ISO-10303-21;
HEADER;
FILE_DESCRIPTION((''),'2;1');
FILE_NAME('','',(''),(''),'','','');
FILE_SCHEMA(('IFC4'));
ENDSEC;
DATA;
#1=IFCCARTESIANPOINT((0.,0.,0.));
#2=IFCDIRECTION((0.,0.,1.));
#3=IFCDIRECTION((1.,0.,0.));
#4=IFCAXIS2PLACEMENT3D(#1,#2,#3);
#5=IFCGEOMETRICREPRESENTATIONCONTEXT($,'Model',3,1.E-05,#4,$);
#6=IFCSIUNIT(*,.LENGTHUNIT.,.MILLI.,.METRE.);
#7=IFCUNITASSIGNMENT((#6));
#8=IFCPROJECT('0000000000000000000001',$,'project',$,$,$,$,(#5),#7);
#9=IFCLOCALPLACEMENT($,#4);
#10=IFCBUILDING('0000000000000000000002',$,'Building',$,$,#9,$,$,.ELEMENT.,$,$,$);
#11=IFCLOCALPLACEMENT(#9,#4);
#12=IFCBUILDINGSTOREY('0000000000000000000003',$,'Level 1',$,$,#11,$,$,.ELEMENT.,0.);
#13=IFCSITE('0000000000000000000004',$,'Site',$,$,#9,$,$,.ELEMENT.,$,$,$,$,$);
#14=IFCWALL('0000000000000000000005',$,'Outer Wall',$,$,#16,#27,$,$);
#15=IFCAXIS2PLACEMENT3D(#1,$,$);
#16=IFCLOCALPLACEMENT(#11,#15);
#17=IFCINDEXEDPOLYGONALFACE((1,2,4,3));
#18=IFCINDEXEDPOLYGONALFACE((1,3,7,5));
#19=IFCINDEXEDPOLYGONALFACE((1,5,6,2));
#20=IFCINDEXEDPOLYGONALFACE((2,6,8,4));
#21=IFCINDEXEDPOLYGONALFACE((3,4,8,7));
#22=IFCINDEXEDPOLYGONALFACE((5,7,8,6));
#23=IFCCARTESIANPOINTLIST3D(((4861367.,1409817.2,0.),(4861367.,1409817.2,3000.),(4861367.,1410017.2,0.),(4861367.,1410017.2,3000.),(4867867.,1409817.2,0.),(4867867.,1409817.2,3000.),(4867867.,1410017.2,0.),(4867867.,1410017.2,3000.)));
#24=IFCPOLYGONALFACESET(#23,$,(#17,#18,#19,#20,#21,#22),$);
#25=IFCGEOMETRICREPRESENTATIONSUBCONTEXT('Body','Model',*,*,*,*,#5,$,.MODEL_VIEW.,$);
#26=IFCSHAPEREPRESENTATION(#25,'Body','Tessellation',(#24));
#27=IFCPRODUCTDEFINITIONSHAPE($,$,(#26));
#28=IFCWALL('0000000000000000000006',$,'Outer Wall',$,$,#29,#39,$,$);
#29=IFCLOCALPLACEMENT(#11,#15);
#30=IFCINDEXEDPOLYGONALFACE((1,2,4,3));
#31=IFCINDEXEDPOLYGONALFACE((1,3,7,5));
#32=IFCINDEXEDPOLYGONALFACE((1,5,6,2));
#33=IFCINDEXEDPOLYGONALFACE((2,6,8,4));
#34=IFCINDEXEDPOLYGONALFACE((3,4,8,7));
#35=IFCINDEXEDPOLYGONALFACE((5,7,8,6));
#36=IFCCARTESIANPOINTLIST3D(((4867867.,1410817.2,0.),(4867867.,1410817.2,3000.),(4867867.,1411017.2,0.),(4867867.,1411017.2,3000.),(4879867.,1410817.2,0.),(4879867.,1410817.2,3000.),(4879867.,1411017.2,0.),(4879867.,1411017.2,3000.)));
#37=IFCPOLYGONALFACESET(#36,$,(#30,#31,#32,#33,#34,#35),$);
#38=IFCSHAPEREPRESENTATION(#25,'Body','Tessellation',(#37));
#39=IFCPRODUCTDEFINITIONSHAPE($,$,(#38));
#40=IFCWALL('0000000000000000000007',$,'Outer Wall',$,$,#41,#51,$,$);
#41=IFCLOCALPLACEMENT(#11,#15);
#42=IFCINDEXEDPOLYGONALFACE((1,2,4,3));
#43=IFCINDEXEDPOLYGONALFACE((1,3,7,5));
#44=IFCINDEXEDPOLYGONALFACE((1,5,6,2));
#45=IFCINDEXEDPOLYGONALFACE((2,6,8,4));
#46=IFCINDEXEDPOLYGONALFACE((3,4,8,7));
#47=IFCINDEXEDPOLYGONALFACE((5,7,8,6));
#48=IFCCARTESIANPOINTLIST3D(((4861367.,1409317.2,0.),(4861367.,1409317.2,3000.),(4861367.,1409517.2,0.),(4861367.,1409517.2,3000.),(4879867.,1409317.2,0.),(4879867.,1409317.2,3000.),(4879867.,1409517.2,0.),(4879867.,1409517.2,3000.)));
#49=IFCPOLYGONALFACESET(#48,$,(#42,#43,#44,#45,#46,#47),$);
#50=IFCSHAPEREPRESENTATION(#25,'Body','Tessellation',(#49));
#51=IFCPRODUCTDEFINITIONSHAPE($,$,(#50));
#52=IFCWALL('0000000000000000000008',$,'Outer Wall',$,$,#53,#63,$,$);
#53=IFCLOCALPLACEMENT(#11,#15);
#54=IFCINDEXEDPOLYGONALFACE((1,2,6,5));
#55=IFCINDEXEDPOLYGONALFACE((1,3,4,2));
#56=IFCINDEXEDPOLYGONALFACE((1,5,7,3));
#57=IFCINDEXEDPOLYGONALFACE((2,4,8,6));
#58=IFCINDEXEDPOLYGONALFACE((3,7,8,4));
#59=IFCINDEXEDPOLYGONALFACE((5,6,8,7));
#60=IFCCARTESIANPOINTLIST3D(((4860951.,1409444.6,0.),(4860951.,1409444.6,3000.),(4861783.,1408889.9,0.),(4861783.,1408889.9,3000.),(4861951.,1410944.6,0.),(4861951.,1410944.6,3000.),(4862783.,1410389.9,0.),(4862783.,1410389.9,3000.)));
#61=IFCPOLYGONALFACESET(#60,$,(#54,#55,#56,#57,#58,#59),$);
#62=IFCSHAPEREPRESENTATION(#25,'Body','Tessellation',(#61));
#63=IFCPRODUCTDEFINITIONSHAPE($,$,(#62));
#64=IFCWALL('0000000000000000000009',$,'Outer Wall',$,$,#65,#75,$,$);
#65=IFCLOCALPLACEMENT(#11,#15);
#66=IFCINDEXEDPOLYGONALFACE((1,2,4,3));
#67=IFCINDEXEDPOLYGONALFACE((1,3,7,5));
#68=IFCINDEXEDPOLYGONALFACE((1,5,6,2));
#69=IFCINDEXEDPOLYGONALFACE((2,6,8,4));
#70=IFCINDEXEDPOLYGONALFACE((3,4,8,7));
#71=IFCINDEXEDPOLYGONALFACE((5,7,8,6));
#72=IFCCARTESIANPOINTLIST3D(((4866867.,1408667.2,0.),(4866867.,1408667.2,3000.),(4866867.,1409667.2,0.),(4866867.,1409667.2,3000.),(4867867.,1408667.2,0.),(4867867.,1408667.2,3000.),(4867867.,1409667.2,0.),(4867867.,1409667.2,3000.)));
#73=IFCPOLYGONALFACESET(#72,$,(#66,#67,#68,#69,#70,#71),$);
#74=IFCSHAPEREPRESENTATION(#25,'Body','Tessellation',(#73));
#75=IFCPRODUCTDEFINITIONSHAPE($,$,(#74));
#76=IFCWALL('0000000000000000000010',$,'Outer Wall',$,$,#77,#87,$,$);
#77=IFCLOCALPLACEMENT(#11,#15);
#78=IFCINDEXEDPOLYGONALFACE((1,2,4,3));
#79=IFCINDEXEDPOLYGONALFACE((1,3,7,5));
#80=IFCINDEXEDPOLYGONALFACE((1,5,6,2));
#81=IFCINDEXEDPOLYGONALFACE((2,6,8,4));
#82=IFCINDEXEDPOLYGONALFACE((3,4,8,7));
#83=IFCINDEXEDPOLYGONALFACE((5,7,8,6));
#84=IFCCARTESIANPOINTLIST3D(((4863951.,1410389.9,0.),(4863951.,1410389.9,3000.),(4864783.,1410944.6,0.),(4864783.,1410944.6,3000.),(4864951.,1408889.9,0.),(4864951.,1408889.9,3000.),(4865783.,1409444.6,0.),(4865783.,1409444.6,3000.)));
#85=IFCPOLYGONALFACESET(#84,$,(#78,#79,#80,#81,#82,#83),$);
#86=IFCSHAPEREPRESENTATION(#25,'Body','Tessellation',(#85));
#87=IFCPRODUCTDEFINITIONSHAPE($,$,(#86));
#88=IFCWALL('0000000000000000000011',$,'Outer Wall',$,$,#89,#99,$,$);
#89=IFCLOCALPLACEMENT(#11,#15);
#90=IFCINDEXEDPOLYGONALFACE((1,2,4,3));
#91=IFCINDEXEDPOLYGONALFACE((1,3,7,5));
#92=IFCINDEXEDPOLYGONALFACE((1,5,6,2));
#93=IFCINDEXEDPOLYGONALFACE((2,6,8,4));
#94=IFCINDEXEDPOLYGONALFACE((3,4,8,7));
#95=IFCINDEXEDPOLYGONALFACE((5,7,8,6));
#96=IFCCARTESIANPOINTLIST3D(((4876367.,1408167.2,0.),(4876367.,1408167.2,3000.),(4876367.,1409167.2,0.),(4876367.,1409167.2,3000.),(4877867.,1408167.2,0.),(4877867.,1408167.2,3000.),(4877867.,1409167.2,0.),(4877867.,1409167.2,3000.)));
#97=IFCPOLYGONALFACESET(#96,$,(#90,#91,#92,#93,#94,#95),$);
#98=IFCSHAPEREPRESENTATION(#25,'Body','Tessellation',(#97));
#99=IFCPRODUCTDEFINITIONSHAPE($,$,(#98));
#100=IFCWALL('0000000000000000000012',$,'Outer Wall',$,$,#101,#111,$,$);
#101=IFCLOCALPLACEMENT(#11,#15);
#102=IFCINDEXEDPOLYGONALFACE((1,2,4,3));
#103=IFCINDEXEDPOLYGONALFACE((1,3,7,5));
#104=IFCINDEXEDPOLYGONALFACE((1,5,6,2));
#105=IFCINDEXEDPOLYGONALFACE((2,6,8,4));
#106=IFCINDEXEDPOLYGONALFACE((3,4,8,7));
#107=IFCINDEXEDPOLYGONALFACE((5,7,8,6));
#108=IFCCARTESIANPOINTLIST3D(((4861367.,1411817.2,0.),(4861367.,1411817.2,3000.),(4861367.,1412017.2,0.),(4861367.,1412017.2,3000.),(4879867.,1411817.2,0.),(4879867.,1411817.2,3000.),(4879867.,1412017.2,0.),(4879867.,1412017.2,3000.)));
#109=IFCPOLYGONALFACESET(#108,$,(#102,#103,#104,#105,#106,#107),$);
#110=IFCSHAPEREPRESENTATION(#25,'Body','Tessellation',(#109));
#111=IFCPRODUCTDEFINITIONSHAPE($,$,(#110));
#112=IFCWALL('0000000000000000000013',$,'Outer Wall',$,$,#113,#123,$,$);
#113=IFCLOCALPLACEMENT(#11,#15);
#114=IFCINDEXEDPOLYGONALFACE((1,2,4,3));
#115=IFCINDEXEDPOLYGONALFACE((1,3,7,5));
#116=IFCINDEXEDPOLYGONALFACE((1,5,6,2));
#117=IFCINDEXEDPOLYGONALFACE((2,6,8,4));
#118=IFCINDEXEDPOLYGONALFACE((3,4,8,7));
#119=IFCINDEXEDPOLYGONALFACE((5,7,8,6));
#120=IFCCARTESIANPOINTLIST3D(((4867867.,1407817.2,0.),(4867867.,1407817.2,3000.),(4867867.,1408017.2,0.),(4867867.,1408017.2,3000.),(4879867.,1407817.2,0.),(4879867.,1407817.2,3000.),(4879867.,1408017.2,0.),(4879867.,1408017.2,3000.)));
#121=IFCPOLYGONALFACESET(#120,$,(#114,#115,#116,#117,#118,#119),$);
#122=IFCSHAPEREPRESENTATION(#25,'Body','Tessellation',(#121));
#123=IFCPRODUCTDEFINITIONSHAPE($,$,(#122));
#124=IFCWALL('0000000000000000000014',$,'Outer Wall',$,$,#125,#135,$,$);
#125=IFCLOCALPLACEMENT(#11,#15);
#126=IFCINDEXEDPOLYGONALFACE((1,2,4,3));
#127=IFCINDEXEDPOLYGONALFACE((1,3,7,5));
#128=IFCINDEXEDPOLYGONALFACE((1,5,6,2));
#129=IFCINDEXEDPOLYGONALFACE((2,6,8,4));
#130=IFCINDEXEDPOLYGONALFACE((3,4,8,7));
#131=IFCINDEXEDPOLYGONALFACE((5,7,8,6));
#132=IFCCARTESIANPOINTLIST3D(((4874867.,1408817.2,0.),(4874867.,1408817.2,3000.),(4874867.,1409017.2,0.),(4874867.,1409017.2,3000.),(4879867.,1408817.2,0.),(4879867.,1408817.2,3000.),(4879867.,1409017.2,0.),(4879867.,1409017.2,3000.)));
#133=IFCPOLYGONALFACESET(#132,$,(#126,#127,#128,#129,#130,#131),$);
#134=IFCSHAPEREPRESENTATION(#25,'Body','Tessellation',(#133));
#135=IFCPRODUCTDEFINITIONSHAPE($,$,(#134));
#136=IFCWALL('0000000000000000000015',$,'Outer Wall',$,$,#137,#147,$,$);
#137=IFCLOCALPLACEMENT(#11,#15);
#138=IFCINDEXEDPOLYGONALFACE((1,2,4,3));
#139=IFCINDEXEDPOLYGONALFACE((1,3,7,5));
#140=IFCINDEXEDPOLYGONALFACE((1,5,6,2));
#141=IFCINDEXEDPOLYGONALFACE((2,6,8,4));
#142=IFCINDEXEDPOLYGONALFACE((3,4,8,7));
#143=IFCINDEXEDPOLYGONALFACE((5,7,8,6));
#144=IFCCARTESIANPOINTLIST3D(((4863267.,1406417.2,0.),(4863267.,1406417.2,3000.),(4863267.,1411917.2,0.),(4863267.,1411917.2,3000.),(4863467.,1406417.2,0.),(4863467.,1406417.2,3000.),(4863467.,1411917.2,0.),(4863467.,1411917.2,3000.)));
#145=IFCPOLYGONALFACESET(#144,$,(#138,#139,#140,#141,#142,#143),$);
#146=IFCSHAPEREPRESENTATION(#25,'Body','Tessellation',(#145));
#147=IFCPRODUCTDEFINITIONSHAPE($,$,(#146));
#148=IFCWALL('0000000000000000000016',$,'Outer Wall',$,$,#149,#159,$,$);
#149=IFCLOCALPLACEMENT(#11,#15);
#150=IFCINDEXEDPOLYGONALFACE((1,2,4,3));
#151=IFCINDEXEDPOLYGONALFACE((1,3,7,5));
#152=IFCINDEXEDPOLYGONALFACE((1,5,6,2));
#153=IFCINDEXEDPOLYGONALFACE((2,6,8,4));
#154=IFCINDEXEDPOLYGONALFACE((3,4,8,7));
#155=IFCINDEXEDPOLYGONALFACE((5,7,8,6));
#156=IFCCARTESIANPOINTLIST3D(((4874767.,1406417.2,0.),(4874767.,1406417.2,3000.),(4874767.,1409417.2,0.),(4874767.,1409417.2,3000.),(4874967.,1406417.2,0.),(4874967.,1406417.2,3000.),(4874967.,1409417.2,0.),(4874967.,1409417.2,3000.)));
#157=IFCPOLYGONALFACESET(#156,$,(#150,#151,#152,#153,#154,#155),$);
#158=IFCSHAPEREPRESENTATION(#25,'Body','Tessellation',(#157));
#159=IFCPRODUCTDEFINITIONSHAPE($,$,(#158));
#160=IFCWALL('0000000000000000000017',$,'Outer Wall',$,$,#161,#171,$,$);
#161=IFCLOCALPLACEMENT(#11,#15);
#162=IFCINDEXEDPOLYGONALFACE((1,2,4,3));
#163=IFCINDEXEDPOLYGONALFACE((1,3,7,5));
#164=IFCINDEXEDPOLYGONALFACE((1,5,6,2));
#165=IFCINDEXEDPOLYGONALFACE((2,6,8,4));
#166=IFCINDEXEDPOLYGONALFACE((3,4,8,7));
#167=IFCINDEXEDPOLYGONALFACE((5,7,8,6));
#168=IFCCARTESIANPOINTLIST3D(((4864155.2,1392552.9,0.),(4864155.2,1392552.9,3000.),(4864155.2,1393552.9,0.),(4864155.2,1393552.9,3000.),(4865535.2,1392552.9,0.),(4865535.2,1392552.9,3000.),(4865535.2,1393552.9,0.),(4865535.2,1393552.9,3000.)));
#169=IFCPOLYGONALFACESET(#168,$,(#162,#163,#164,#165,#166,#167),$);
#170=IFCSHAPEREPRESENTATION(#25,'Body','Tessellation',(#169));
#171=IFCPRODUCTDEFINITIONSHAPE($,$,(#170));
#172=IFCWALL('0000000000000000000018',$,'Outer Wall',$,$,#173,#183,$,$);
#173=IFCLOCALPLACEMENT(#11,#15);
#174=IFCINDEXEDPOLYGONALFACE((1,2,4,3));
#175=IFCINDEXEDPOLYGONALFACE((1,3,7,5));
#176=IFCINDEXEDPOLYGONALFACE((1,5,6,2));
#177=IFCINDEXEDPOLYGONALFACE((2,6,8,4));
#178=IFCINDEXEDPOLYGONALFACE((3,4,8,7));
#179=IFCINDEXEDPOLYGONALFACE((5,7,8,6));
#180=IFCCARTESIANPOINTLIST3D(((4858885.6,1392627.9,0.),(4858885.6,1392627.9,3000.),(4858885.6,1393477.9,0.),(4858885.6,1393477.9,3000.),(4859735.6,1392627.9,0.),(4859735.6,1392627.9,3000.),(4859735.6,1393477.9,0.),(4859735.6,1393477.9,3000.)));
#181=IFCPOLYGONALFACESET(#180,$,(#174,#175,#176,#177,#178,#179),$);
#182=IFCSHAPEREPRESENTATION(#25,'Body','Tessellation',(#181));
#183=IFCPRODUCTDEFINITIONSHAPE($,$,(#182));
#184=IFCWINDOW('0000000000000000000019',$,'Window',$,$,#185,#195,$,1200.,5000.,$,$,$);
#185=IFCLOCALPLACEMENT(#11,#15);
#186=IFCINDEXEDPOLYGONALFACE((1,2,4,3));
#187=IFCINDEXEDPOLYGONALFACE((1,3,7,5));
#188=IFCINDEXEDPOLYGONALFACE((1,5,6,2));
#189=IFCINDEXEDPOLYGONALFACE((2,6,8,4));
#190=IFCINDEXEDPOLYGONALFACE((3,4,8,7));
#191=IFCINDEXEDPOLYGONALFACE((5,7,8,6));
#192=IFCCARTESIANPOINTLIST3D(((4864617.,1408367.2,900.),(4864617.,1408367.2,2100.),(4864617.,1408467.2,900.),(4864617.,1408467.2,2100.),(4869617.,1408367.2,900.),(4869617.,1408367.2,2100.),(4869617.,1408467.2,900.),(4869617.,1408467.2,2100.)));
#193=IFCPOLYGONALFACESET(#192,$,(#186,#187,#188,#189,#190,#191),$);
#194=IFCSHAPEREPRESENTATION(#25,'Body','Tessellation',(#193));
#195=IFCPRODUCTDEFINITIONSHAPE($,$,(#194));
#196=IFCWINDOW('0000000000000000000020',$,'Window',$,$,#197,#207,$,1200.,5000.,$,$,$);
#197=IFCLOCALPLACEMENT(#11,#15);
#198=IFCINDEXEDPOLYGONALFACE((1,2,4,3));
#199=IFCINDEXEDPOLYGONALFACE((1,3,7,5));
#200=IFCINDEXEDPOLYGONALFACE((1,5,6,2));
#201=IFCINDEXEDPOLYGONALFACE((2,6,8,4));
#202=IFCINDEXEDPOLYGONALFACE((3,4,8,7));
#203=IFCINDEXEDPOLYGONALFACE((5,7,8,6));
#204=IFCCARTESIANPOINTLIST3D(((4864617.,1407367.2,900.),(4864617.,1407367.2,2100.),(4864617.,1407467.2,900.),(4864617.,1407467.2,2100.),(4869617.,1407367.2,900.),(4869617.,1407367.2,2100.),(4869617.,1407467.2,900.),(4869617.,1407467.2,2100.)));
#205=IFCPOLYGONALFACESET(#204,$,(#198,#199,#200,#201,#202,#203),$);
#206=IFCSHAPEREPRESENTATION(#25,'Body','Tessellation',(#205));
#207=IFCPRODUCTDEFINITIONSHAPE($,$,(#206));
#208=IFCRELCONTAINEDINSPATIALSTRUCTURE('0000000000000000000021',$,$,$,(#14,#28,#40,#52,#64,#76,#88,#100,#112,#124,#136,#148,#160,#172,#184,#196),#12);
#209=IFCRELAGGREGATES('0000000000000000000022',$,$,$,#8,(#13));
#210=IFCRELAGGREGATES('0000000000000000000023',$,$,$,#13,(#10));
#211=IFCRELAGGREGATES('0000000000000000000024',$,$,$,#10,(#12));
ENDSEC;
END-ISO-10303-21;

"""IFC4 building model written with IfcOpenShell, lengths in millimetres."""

from ifc_helpers import new_model, si_unit, frame, frame_2d, origin_with_axes, place, context, subcontext, project, spatial, rectangle, extrude, element, save


model = new_model("IFC4")

# Units and contexts
model_context = context("Model", 3, precision=1e-05, world=origin_with_axes())
body_context = subcontext(model_context, "Body", "Model", "MODEL_VIEW")
ifc_project = project(units=[si_unit("LENGTHUNIT", "METRE", prefix="MILLI")], contexts=[model_context])

# Site, building, storey
placement = place(None, origin_with_axes())
site = spatial("IfcSite", under=ifc_project, at=placement, Name="Site", CompositionType="ELEMENT")
building = spatial("IfcBuilding", under=site, at=placement, Name="Building", CompositionType="ELEMENT")
storey_placement = place(placement, origin_with_axes())
storey = spatial("IfcBuildingStorey", under=building, at=storey_placement, Name="Level 1", CompositionType="ELEMENT", Elevation=0.0)

# Walls
wall_1_placement = place(placement, frame((4861367.0, 1409917.2, 0.0), z_axis=(0.0, 0.0, 1.0), x_axis=(1.0, 0.0, 0.0)))
element("IfcWall", 1, at=wall_1_placement, inside=storey, Name="Outer Wall", context=body_context, shape_type="SweptSolid", body=[
    extrude(rectangle(XDim=6500.0, YDim=200.0, at=frame_2d((3250.0, 0.0), x_axis=(1.0, 0.0))), origin_with_axes(), (0.0, 0.0, 1.0), 3000.0),
])
wall_2_placement = place(placement, frame((4867867.0, 1410917.2, 0.0), z_axis=(0.0, 0.0, 1.0), x_axis=(1.0, 0.0, 0.0)))
element("IfcWall", 2, at=wall_2_placement, inside=storey, Name="Outer Wall", context=body_context, shape_type="SweptSolid", body=[
    extrude(rectangle(XDim=12000.0, YDim=200.0, at=frame_2d((6000.0, 0.0), x_axis=(1.0, 0.0))), origin_with_axes(), (0.0, 0.0, 1.0), 3000.0),
])
wall_3_placement = place(placement, frame((4861367.0, 1409417.2, 0.0), z_axis=(0.0, 0.0, 1.0), x_axis=(1.0, 0.0, 0.0)))
element("IfcWall", 3, at=wall_3_placement, inside=storey, Name="Outer Wall", context=body_context, shape_type="SweptSolid", body=[
    extrude(rectangle(XDim=18500.0, YDim=200.0, at=frame_2d((9250.0, 0.0), x_axis=(1.0, 0.0))), origin_with_axes(), (0.0, 0.0, 1.0), 3000.0),
])
wall_4_placement = place(placement, frame((4862367.0, 1410667.2, 0.0), z_axis=(0.0, 0.0, 1.0), x_axis=(-0.5547, -0.83205, 0.0)))
element("IfcWall", 4, at=wall_4_placement, inside=storey, Name="Outer Wall", context=body_context, shape_type="SweptSolid", body=[
    extrude(rectangle(XDim=1802.8, YDim=1000.0, at=frame_2d((901.4, 0.0), x_axis=(1.0, 0.0))), origin_with_axes(), (0.0, 0.0, 1.0), 3000.0),
])
wall_5_placement = place(placement, frame((4866867.0, 1409167.2, 0.0), z_axis=(0.0, 0.0, 1.0), x_axis=(1.0, 0.0, 0.0)))
element("IfcWall", 5, at=wall_5_placement, inside=storey, Name="Outer Wall", context=body_context, shape_type="SweptSolid", body=[
    extrude(rectangle(XDim=1000.0, YDim=1000.0, at=frame_2d((500.0, 0.0), x_axis=(1.0, 0.0))), origin_with_axes(), (0.0, 0.0, 1.0), 3000.0),
])
wall_6_placement = place(placement, frame((4865367.0, 1409167.2, 0.0), z_axis=(0.0, 0.0, 1.0), x_axis=(-0.5547, 0.83205, 0.0)))
element("IfcWall", 6, at=wall_6_placement, inside=storey, Name="Outer Wall", context=body_context, shape_type="SweptSolid", body=[
    extrude(rectangle(XDim=1802.8, YDim=1000.0, at=frame_2d((901.4, 0.0), x_axis=(1.0, 0.0))), origin_with_axes(), (0.0, 0.0, 1.0), 3000.0),
])
wall_7_placement = place(placement, frame((4877867.0, 1408667.2, 0.0), z_axis=(0.0, 0.0, 1.0), x_axis=(-1.0, 0.0, 0.0)))
element("IfcWall", 7, at=wall_7_placement, inside=storey, Name="Outer Wall", context=body_context, shape_type="SweptSolid", body=[
    extrude(rectangle(XDim=1500.0, YDim=1000.0, at=frame_2d((750.0, 0.0), x_axis=(1.0, 0.0))), origin_with_axes(), (0.0, 0.0, 1.0), 3000.0),
])
wall_8_placement = place(placement, frame((4861367.0, 1411917.2, 0.0), z_axis=(0.0, 0.0, 1.0), x_axis=(1.0, 0.0, 0.0)))
element("IfcWall", 8, at=wall_8_placement, inside=storey, Name="Outer Wall", context=body_context, shape_type="SweptSolid", body=[
    extrude(rectangle(XDim=18500.0, YDim=200.0, at=frame_2d((9250.0, 0.0), x_axis=(1.0, 0.0))), origin_with_axes(), (0.0, 0.0, 1.0), 3000.0),
])
wall_9_placement = place(placement, frame((4867867.0, 1407917.2, 0.0), z_axis=(0.0, 0.0, 1.0), x_axis=(1.0, 0.0, 0.0)))
element("IfcWall", 9, at=wall_9_placement, inside=storey, Name="Outer Wall", context=body_context, shape_type="SweptSolid", body=[
    extrude(rectangle(XDim=12000.0, YDim=200.0, at=frame_2d((6000.0, 0.0), x_axis=(1.0, 0.0))), origin_with_axes(), (0.0, 0.0, 1.0), 3000.0),
])
wall_10_placement = place(placement, frame((4874867.0, 1408917.2, 0.0), z_axis=(0.0, 0.0, 1.0), x_axis=(1.0, 0.0, 0.0)))
element("IfcWall", 10, at=wall_10_placement, inside=storey, Name="Outer Wall", context=body_context, shape_type="SweptSolid", body=[
    extrude(rectangle(XDim=5000.0, YDim=200.0, at=frame_2d((2500.0, 0.0), x_axis=(1.0, 0.0))), origin_with_axes(), (0.0, 0.0, 1.0), 3000.0),
])
wall_11_placement = place(placement, frame((4863367.0, 1406417.2, 0.0), z_axis=(0.0, 0.0, 1.0), x_axis=(0.0, 1.0, 0.0)))
element("IfcWall", 11, at=wall_11_placement, inside=storey, Name="Outer Wall", context=body_context, shape_type="SweptSolid", body=[
    extrude(rectangle(XDim=5500.0, YDim=200.0, at=frame_2d((2750.0, 0.0), x_axis=(1.0, 0.0))), origin_with_axes(), (0.0, 0.0, 1.0), 3000.0),
])
wall_12_placement = place(placement, frame((4874867.0, 1409417.2, 0.0), z_axis=(0.0, 0.0, 1.0), x_axis=(0.0, -1.0, 0.0)))
element("IfcWall", 12, at=wall_12_placement, inside=storey, Name="Outer Wall", context=body_context, shape_type="SweptSolid", body=[
    extrude(rectangle(XDim=3000.0, YDim=200.0, at=frame_2d((1500.0, 0.0), x_axis=(1.0, 0.0))), origin_with_axes(), (0.0, 0.0, 1.0), 3000.0),
])
wall_13_placement = place(placement, frame((4864155.2, 1393052.9, 0.0), z_axis=(0.0, 0.0, 1.0), x_axis=(1.0, 0.0, 0.0)))
element("IfcWall", 13, at=wall_13_placement, inside=storey, Name="Outer Wall", context=body_context, shape_type="SweptSolid", body=[
    extrude(rectangle(XDim=1380.0, YDim=1000.0, at=frame_2d((690.0, 0.0), x_axis=(1.0, 0.0))), origin_with_axes(), (0.0, 0.0, 1.0), 3000.0),
])
wall_14_placement = place(placement, frame((4858885.6, 1393052.9, 0.0), z_axis=(0.0, 0.0, 1.0), x_axis=(1.0, 0.0, 0.0)))
element("IfcWall", 14, at=wall_14_placement, inside=storey, Name="Outer Wall", context=body_context, shape_type="SweptSolid", body=[
    extrude(rectangle(XDim=850.0, YDim=850.0, at=frame_2d((425.0, 0.0), x_axis=(1.0, 0.0))), origin_with_axes(), (0.0, 0.0, 1.0), 3000.0),
])

# Windows
for number, where, z_axis, x_axis, name in (
    (15, (4864617.0, 1408417.2, 900.0), (0.0, 0.0, 1.0), (1.0, 0.0, 0.0), "Window"),
    (16, (4864617.0, 1407417.2, 900.0), (0.0, 0.0, 1.0), (1.0, 0.0, 0.0), "Window"),
):
    element("IfcWindow", number, at=place(placement, frame(where, z_axis=z_axis, x_axis=x_axis)), inside=storey, Name=name, OverallHeight=1200.0, OverallWidth=5000.0, context=body_context, shape_type="SweptSolid", body=[
        extrude(rectangle(XDim=5000.0, YDim=100.0, at=frame_2d((2500.0, 0.0), x_axis=(1.0, 0.0))), origin_with_axes(), (0.0, 0.0, 1.0), 1200.0),
    ])

save(model, "model.ifc")
